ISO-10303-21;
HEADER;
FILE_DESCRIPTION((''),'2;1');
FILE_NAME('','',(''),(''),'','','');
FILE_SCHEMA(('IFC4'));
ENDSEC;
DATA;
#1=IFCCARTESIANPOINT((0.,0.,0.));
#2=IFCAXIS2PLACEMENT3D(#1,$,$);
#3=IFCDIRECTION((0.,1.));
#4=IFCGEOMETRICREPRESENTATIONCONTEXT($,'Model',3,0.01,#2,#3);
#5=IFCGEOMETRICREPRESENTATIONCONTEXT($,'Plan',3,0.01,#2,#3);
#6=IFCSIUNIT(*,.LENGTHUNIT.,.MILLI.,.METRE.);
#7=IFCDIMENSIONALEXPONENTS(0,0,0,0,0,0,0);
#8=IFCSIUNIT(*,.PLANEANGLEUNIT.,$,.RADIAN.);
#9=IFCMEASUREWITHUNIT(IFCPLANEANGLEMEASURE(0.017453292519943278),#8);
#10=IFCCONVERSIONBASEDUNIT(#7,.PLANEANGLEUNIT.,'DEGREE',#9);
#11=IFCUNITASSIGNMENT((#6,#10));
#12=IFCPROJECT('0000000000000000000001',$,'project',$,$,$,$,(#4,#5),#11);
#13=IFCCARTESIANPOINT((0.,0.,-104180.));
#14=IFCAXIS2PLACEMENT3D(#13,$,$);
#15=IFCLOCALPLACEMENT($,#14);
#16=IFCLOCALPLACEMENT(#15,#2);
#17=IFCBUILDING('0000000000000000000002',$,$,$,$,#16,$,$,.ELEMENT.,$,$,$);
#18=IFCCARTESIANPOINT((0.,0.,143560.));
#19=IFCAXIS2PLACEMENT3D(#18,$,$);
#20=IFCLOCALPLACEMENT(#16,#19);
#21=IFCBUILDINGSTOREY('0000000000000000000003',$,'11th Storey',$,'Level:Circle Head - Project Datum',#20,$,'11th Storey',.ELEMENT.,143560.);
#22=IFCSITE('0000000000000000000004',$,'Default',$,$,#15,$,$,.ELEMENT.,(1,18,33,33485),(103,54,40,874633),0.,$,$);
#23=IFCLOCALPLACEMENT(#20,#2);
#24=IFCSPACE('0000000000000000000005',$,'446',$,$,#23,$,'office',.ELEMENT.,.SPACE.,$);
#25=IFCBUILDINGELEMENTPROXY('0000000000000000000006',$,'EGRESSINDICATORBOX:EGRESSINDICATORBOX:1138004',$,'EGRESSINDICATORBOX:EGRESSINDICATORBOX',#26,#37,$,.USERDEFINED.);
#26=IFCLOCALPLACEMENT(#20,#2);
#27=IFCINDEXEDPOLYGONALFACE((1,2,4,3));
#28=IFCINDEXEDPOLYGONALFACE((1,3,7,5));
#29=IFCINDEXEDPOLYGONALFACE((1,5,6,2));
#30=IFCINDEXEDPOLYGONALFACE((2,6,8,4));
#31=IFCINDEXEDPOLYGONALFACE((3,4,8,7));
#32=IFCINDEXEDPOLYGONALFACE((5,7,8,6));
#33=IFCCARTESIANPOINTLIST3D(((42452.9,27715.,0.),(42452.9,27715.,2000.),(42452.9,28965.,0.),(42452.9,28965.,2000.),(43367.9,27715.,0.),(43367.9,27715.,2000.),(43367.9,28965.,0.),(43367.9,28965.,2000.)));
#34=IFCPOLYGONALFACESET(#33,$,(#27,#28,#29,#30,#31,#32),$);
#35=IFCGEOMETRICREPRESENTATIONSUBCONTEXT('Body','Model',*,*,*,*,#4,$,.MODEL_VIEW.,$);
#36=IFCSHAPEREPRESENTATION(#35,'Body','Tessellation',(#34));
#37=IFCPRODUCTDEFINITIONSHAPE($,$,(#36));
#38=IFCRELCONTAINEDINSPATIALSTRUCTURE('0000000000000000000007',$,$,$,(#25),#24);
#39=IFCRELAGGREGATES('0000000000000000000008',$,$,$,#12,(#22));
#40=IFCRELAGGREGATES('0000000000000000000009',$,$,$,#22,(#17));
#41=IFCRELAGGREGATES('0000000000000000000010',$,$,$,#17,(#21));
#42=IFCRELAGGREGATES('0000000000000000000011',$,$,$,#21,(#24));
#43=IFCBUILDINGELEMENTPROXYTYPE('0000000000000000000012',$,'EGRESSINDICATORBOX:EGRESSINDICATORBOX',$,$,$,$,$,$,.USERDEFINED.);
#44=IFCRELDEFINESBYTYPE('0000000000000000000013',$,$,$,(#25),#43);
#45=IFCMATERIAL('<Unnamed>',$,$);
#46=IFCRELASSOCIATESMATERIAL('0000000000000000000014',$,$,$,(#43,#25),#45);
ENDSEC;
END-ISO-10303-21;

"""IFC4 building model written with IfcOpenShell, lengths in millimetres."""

from ifc_helpers import new_model, entity, si_unit, converted_unit, direction, frame, origin, place, context, subcontext, project, spatial, indexed_curve, outline, extrude, source, transform, mapped, material, type_object, type_shapes, element, save


model = new_model("IFC4")

# Units and contexts
model_context = context("Model", 3, precision=0.01, world=origin(), true_north=direction((0.0, 1.0)))
plan_context = context("Plan", 3, precision=0.01, world=origin(), true_north=direction((0.0, 1.0)))
body_context = subcontext(model_context, "Body", "Model", "MODEL_VIEW")
ifc_project = project(units=[si_unit("LENGTHUNIT", "METRE", prefix="MILLI"), converted_unit("PLANEANGLEUNIT", "DEGREE", entity("IfcPlaneAngleMeasure", 0.017453292519943278), si_unit("PLANEANGLEUNIT", "RADIAN"), dimensions=[0, 0, 0, 0, 0, 0, 0])], contexts=[model_context, plan_context])

# Site, building, storey
site_placement = place(None, frame((0.0, 0.0, -104180.0)))
site = spatial("IfcSite", under=ifc_project, at=site_placement, Name="Default", CompositionType="ELEMENT", RefLatitude=(1, 18, 33, 33485), RefLongitude=(103, 54, 40, 874633), RefElevation=0.0)
building_placement = place(site_placement, origin())
building = spatial("IfcBuilding", under=site, at=building_placement, CompositionType="ELEMENT")
storey_placement = place(building_placement, frame((0.0, 0.0, 143560.0)))
storey = spatial("IfcBuildingStorey", under=building, at=storey_placement, Name="11th Storey", ObjectType="Level:Circle Head - Project Datum", LongName="11th Storey", CompositionType="ELEMENT", Elevation=143560.0)

# Shared definitions
ifc_material_1 = material(Name="<Unnamed>")

# Shared definitions
space_1_placement = place(storey_placement, origin())
space_1 = spatial("IfcSpace", under=storey, at=space_1_placement, Name="446", LongName="office", CompositionType="ELEMENT", PredefinedType="SPACE")

# Building element proxy
building_element_proxy_type_1 = type_object("IfcBuildingElementProxyType", Name="EGRESSINDICATORBOX:EGRESSINDICATORBOX", PredefinedType="USERDEFINED", material=ifc_material_1)
shared_shape_1 = source(origin(), body_context, "Body", "SweptSolid", [
    extrude(outline(indexed_curve([(-457.5, -625.0), (457.5, -625.0), (457.5, 625.0), (-457.5, 625.0), (-457.5, -625.0)], self_intersect=False)), frame((0.0, 0.0, 0.0), z_axis=(0.0, 0.0, 1.0), x_axis=(-1.0, 0.0, 0.0)), (0.0, 0.0, 1.0), 2000.0),
])
type_shapes(building_element_proxy_type_1, [shared_shape_1])
proxy_1_placement = place(space_1_placement, frame((42910.4, 28340.0, 0.0)))
element("IfcBuildingElementProxy", 1, at=proxy_1_placement, inside=space_1, type_object=building_element_proxy_type_1, material=ifc_material_1, Name="EGRESSINDICATORBOX:EGRESSINDICATORBOX:1138004", ObjectType="EGRESSINDICATORBOX:EGRESSINDICATORBOX", PredefinedType="USERDEFINED", context=body_context, shape_type="MappedRepresentation", body=[
    mapped(shared_shape_1, transform((0.0, 0.0, 0.0), scale=1.0)),
])

save(model, "model.ifc")
